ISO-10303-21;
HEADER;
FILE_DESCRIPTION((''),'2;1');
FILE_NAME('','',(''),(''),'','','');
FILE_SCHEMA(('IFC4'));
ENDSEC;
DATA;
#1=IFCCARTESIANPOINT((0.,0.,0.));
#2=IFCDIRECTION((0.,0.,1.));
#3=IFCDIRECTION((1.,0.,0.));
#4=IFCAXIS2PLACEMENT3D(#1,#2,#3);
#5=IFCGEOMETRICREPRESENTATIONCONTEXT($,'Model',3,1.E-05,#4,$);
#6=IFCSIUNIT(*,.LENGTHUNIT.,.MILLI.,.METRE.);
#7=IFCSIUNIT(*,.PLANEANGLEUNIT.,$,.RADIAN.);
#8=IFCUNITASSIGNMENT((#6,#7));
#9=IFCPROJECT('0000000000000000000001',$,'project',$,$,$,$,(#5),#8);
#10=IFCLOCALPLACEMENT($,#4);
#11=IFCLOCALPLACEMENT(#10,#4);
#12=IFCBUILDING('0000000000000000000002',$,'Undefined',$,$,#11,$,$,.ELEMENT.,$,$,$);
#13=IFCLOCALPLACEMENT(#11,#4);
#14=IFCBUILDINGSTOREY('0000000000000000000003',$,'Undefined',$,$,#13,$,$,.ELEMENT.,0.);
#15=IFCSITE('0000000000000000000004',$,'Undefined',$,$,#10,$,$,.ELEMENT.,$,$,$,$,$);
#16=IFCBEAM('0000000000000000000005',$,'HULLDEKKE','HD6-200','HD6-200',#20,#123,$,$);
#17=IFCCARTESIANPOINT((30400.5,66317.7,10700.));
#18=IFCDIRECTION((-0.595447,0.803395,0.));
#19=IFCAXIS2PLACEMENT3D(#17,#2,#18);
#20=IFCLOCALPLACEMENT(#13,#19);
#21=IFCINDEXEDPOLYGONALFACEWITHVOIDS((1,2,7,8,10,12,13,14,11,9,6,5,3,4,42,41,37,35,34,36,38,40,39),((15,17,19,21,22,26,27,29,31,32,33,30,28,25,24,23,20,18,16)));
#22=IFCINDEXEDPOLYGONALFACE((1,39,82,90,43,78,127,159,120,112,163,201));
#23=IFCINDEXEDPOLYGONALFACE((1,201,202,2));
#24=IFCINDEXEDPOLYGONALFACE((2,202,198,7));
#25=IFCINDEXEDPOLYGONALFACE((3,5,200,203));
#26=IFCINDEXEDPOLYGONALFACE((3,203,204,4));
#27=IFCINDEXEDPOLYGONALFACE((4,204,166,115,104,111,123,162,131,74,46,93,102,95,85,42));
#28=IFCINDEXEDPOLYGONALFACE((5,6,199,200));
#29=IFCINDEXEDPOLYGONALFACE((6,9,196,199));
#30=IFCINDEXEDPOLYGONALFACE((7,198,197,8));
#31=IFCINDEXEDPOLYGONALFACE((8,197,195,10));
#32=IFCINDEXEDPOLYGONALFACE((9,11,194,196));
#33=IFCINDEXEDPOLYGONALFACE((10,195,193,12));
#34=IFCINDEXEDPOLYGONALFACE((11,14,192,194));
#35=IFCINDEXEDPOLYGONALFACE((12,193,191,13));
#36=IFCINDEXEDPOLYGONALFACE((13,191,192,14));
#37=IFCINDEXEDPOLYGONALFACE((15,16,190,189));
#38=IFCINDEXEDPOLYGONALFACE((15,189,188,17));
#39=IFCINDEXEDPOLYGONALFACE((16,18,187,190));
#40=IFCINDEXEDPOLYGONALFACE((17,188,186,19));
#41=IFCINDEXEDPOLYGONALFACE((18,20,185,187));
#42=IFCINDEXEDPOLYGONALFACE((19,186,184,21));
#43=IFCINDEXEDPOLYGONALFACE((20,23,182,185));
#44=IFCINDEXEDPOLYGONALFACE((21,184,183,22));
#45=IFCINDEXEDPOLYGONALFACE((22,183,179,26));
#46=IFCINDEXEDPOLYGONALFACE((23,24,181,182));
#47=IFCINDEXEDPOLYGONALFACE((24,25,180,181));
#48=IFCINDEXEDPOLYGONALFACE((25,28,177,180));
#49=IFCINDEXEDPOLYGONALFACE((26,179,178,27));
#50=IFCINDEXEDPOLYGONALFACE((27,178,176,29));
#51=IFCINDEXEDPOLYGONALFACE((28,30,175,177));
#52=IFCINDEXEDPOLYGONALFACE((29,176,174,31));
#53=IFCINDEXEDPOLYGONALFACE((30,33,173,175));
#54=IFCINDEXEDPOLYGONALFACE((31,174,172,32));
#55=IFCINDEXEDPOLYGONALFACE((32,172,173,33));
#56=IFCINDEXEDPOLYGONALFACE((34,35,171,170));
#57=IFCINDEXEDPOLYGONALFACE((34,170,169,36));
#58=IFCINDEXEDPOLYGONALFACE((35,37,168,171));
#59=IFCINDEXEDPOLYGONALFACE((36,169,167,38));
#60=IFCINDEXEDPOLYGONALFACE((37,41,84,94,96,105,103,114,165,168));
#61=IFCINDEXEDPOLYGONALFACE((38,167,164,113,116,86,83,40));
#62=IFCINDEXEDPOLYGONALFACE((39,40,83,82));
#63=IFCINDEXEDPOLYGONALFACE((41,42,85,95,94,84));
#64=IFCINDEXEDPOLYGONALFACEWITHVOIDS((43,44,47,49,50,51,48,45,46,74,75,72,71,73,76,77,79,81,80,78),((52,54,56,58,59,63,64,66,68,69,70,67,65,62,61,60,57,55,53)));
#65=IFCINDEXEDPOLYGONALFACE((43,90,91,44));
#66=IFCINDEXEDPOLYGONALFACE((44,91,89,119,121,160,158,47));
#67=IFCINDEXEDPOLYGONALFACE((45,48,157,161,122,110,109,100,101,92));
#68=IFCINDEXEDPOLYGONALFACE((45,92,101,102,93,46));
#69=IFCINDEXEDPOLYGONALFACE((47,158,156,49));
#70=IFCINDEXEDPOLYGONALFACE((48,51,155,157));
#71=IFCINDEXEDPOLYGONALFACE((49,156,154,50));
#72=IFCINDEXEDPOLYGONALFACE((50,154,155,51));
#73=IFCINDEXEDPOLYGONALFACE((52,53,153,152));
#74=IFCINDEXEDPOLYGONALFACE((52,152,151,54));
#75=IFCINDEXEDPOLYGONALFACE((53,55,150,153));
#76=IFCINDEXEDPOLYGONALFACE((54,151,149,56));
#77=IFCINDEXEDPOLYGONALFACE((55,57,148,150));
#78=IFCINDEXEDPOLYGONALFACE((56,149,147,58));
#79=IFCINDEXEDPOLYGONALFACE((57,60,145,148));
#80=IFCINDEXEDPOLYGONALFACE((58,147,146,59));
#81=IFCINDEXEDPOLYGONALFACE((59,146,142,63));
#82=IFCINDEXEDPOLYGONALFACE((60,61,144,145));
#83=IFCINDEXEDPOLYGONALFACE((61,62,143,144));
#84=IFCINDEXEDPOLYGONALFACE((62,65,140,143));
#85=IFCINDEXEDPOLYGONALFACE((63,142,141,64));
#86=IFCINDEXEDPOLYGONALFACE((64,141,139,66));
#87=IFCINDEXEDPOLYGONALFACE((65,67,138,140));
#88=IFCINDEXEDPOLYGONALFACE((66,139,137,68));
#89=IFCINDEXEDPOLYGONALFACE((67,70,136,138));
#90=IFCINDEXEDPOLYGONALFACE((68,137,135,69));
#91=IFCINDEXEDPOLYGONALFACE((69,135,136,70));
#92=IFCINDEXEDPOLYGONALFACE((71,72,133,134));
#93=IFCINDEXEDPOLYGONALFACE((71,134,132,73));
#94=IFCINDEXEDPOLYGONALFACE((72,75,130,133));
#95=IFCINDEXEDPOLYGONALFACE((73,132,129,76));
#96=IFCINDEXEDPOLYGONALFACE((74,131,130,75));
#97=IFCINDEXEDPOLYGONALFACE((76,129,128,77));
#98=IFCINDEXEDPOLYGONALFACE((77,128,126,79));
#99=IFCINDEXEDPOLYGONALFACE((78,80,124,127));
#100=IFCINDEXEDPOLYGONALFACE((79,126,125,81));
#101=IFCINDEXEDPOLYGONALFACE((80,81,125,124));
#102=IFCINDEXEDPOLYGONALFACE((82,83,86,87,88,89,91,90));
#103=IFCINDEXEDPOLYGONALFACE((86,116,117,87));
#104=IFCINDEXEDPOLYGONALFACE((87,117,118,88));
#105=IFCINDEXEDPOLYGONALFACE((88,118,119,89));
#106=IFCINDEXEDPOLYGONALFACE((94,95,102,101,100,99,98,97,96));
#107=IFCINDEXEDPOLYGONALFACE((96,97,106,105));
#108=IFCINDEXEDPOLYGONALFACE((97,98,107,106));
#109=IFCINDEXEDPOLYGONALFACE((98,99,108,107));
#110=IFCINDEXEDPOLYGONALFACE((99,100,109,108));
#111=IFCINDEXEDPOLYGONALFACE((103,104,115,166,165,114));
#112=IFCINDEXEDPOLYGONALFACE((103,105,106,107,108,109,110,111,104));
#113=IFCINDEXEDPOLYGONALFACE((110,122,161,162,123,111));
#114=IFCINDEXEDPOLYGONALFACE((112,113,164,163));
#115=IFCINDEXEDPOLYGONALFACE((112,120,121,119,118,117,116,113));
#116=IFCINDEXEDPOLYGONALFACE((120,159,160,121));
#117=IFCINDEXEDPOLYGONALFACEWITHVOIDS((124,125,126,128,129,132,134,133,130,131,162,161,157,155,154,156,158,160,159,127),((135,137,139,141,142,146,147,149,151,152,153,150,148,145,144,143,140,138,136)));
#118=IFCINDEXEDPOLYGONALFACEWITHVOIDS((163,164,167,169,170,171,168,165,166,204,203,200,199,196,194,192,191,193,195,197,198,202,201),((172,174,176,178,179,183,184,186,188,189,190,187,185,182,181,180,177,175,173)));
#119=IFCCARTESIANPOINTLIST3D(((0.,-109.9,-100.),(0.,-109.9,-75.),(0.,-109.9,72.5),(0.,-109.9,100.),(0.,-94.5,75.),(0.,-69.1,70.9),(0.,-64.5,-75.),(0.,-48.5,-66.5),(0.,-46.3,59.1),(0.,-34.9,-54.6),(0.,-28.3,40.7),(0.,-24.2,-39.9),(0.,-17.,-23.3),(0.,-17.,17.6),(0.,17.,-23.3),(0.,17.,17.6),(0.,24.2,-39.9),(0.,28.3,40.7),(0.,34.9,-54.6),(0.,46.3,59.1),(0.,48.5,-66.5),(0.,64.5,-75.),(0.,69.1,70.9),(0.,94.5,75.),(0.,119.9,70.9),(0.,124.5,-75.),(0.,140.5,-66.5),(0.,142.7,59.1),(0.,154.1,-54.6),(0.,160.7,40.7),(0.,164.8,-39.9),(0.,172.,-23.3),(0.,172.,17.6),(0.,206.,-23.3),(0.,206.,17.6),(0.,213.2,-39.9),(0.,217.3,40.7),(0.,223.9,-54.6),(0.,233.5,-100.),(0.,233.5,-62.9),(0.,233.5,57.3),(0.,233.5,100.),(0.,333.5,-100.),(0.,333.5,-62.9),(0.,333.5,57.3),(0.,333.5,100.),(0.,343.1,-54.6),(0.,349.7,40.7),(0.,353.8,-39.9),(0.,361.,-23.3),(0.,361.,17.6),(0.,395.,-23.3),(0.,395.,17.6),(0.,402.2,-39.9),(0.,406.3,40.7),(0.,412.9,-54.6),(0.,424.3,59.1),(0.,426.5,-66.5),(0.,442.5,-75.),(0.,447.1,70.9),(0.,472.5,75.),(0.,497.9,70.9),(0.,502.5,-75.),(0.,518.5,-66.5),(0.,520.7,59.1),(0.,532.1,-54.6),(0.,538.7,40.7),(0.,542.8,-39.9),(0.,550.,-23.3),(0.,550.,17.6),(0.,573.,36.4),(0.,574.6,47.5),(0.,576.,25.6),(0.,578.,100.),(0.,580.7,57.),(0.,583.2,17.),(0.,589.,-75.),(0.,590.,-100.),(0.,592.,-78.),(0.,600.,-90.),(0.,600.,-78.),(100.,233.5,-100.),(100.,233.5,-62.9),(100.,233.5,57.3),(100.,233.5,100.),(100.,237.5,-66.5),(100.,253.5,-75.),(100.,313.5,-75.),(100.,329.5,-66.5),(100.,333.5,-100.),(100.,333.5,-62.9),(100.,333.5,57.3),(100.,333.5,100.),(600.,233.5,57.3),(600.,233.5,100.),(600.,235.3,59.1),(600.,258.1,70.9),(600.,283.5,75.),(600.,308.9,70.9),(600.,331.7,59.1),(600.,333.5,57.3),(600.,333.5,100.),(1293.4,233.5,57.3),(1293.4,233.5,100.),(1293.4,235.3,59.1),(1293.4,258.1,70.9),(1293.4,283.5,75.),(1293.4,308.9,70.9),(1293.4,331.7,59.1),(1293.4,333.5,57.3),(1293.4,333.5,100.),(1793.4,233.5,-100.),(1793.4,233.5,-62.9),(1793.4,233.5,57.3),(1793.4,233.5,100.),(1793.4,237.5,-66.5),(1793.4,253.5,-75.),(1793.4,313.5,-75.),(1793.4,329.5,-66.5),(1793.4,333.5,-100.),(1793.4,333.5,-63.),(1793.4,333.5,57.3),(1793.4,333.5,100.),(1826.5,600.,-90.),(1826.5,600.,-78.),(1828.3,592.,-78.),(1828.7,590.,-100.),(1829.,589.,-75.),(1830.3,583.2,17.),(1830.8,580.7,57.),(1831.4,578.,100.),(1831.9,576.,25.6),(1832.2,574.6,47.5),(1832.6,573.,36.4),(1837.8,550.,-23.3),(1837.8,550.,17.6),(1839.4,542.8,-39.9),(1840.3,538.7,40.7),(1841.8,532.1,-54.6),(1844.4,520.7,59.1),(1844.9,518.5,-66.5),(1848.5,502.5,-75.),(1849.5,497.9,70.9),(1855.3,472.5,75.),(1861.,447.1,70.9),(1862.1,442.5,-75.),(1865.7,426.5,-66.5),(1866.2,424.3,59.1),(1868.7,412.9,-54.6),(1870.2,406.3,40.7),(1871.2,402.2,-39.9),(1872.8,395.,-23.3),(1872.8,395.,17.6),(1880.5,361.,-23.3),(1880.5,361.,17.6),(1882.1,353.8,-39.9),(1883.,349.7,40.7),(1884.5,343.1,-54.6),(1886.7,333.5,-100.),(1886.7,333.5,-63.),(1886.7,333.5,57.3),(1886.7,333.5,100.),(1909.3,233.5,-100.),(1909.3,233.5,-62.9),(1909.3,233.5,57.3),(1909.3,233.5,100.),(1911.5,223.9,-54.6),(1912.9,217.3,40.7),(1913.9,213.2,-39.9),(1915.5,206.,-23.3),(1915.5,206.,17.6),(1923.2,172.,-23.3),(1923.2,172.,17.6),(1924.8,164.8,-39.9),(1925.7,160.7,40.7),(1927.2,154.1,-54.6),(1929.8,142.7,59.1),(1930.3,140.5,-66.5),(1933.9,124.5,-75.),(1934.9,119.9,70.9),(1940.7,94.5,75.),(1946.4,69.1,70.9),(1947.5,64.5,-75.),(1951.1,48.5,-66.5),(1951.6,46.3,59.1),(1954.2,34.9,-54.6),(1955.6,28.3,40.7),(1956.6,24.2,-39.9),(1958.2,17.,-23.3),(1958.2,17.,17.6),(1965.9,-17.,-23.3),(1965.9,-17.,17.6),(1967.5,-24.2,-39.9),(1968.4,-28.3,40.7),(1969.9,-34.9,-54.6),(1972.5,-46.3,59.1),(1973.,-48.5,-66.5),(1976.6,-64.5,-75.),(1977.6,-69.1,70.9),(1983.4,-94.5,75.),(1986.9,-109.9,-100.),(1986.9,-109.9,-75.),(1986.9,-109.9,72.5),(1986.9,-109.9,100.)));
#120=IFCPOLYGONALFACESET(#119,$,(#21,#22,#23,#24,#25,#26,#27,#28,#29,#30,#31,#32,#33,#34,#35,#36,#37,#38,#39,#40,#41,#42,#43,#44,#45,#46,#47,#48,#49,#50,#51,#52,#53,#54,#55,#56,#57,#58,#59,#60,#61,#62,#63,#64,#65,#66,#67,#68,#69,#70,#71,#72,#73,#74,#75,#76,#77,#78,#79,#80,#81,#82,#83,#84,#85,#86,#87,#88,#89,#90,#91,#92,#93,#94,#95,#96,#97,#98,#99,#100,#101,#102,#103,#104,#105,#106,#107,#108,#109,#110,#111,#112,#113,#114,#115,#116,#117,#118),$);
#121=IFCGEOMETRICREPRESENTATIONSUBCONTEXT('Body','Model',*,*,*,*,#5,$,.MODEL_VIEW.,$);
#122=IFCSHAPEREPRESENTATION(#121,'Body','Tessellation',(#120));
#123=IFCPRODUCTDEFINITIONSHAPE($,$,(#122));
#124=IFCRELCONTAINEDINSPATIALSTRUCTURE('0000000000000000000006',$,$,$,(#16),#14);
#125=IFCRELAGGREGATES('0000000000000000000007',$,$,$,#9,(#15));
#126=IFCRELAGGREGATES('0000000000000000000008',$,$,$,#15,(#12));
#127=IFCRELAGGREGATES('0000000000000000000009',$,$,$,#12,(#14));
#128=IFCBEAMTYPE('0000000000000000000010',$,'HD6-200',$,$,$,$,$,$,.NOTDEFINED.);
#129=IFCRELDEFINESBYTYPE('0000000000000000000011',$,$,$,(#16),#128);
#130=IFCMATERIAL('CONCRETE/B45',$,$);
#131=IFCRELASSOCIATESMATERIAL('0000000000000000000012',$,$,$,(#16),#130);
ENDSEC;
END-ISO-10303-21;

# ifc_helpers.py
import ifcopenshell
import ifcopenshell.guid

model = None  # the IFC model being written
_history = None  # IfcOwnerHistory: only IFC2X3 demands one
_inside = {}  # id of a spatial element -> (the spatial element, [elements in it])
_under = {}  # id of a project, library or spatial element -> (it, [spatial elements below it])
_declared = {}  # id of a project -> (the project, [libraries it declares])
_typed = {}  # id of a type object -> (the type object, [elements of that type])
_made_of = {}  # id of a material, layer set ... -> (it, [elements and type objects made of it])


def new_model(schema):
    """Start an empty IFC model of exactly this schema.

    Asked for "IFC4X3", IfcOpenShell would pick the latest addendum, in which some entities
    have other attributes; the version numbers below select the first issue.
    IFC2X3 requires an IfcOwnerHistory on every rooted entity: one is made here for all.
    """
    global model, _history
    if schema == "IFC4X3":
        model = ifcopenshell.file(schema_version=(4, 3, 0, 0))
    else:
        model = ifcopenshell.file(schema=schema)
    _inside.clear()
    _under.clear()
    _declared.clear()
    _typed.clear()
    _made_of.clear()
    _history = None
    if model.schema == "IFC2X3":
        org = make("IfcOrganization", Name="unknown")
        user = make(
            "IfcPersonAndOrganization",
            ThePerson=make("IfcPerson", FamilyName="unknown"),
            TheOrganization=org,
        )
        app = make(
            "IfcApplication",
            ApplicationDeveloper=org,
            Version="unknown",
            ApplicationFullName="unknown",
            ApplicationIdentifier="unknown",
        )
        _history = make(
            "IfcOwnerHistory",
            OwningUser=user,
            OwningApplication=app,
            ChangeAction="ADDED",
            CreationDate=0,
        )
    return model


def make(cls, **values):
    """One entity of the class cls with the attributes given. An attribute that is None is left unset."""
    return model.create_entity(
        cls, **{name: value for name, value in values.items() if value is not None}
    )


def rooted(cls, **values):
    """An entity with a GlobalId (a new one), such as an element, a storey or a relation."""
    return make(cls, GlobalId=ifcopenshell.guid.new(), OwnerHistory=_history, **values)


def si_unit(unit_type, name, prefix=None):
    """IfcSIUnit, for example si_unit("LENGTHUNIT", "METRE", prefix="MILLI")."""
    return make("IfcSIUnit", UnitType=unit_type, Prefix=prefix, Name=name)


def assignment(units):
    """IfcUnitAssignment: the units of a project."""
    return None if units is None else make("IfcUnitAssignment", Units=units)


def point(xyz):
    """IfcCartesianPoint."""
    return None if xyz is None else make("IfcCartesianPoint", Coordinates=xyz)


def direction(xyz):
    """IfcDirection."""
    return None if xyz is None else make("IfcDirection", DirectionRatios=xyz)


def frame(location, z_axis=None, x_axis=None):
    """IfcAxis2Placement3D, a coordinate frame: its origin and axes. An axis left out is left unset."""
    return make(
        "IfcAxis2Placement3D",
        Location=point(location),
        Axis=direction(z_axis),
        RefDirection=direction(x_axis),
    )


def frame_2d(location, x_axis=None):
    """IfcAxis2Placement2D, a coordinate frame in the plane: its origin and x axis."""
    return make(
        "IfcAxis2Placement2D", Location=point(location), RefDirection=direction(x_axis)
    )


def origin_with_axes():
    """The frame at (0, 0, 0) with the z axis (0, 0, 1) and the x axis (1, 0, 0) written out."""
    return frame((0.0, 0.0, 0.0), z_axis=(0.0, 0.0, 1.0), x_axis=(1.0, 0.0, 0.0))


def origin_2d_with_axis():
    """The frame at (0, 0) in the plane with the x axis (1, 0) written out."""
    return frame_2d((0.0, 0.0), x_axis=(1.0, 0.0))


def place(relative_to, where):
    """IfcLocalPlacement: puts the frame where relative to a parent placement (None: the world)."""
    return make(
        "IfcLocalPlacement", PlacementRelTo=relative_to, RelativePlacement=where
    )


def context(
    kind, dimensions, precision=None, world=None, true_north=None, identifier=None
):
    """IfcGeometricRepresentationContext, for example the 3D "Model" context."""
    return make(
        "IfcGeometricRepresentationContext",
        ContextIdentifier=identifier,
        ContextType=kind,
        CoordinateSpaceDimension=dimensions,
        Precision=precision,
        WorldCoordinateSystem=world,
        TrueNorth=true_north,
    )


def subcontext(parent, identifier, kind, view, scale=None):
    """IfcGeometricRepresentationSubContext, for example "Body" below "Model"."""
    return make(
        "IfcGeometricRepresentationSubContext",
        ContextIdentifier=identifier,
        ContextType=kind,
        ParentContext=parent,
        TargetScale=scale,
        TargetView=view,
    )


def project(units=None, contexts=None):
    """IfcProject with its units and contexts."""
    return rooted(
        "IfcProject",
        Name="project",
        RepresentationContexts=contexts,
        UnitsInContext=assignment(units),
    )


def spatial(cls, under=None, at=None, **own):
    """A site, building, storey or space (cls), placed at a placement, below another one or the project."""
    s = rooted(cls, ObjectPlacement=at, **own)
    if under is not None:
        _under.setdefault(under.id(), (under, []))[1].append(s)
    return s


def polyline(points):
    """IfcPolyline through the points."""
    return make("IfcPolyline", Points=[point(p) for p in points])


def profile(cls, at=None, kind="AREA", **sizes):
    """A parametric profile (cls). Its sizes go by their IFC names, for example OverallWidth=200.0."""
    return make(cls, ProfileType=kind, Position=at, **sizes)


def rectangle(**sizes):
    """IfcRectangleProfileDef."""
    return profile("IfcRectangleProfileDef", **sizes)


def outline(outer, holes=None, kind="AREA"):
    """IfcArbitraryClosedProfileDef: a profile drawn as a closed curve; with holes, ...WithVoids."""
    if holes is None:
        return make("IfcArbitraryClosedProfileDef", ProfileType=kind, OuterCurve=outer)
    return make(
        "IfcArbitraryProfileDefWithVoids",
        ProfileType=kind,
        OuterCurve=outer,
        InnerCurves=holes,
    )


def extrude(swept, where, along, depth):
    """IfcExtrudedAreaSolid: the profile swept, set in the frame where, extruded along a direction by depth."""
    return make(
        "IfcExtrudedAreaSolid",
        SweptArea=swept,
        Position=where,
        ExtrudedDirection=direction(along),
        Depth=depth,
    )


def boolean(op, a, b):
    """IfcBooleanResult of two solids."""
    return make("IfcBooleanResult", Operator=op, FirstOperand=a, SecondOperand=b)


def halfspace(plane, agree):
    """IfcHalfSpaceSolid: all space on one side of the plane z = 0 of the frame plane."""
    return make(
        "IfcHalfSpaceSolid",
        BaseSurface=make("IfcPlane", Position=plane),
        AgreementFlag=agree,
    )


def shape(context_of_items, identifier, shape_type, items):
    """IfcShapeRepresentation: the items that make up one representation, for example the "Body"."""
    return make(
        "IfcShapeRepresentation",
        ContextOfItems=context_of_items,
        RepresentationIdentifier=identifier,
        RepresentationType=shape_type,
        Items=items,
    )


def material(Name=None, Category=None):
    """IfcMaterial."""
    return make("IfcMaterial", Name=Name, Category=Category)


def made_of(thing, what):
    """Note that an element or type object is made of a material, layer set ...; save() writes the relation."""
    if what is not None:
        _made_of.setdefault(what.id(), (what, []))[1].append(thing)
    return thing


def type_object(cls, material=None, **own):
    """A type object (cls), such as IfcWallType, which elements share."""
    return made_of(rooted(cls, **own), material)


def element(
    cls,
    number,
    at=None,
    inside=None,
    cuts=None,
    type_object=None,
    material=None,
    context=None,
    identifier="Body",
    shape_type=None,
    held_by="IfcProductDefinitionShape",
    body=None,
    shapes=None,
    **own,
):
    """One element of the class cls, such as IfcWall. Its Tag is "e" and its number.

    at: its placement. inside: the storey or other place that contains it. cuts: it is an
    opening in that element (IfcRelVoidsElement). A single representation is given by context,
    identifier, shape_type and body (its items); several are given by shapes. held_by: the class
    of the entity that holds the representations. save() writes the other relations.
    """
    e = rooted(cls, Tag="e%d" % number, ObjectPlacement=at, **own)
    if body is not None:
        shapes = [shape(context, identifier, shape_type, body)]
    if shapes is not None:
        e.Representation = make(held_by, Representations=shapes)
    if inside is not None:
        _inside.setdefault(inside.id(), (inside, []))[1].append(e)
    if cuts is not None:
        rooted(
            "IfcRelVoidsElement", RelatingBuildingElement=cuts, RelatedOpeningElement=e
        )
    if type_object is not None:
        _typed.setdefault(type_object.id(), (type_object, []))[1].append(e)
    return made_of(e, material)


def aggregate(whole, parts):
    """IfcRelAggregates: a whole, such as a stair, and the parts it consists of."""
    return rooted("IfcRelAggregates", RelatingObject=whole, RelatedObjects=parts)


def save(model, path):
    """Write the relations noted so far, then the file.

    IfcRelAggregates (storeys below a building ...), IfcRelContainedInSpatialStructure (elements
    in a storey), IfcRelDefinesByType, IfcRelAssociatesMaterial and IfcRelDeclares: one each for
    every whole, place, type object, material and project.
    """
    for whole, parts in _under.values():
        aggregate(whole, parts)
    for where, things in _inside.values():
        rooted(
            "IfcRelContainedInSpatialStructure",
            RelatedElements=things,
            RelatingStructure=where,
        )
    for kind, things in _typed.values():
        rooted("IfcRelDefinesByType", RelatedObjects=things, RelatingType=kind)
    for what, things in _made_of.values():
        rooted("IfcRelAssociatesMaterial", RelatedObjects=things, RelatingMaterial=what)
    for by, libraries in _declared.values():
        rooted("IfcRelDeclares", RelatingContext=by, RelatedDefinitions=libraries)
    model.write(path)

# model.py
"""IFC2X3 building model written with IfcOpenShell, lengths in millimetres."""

from ifc_helpers import new_model, si_unit, frame, origin_with_axes, origin_2d_with_axis, place, context, subcontext, project, spatial, polyline, rectangle, outline, extrude, boolean, halfspace, material, type_object, element, save


model = new_model("IFC2X3")

# Units and contexts
model_context = context("Model", 3, precision=1e-05, world=origin_with_axes())
body_context = subcontext(model_context, "Body", "Model", "MODEL_VIEW")
ifc_project = project(units=[si_unit("LENGTHUNIT", "METRE", prefix="MILLI"), si_unit("PLANEANGLEUNIT", "RADIAN")], contexts=[model_context])

# Site, building, storey
site_placement = place(None, origin_with_axes())
site = spatial("IfcSite", under=ifc_project, at=site_placement, Name="Undefined", CompositionType="ELEMENT")
building_placement = place(site_placement, origin_with_axes())
building = spatial("IfcBuilding", under=site, at=building_placement, Name="Undefined", CompositionType="ELEMENT")
storey_placement = place(building_placement, origin_with_axes())
storey = spatial("IfcBuildingStorey", under=building, at=storey_placement, Name="Undefined", CompositionType="ELEMENT", Elevation=0.0)

# Beam
ifc_material_1 = material(Name="CONCRETE/B45")
beam_type_1 = type_object("IfcBeamType", Name="HD6-200", PredefinedType="NOTDEFINED")
beam_1_placement = place(storey_placement, frame((30400.5, 66317.7, 10700.0), z_axis=(0.0, 0.0, 1.0), x_axis=(-0.595447, 0.803395, 0.0)))
element("IfcBeam", 1, at=beam_1_placement, inside=storey, type_object=beam_type_1, material=ifc_material_1, Name="HULLDEKKE", Description="HD6-200", ObjectType="HD6-200", context=body_context, shape_type="CSG", body=[
    boolean("DIFFERENCE", boolean("DIFFERENCE", boolean("DIFFERENCE", boolean("DIFFERENCE", boolean("DIFFERENCE", boolean("DIFFERENCE", extrude(outline(polyline([(589.0, -75.0), (592.0, -78.0), (600.0, -78.0), (600.0, -90.0), (590.0, -100.0), (-590.0, -100.0), (-600.0, -90.0), (-600.0, -78.0), (-592.0, -78.0), (-589.0, -75.0), (-583.2, 17.0), (-576.0, 25.6), (-573.0, 36.4), (-574.6, 47.5), (-580.7, 57.0), (-578.0, 100.0), (578.0, 100.0), (580.7, 57.0), (574.6, 47.5), (573.0, 36.4), (576.0, 25.6), (583.2, 17.0), (589.0, -75.0)]), holes=[polyline([(542.8, -39.9), (550.0, -23.3), (550.0, 17.5), (538.7, 40.7), (520.7, 59.1), (497.9, 70.9), (472.5, 75.0), (447.1, 70.9), (424.3, 59.1), (406.3, 40.7), (395.0, 17.5), (395.0, -23.3), (402.2, -39.9), (412.9, -54.6), (426.5, -66.5), (442.5, -75.0), (502.5, -75.0), (518.5, -66.5), (532.1, -54.6), (542.8, -39.9)]), polyline([(353.8, -39.9), (361.0, -23.3), (361.0, 17.5), (349.7, 40.7), (331.7, 59.1), (308.9, 70.9), (283.5, 75.0), (258.1, 70.9), (235.3, 59.1), (217.3, 40.7), (206.0, 17.5), (206.0, -23.3), (213.2, -39.9), (223.9, -54.6), (237.5, -66.5), (253.5, -75.0), (313.5, -75.0), (329.5, -66.5), (343.1, -54.6), (353.8, -39.9)]), polyline([(164.8, -39.9), (172.0, -23.3), (172.0, 17.5), (160.7, 40.7), (142.7, 59.1), (119.9, 70.9), (94.5, 75.0), (69.1, 70.9), (46.3, 59.1), (28.3, 40.7), (17.0, 17.5), (17.0, -23.3), (24.2, -39.9), (34.9, -54.6), (48.5, -66.5), (64.5, -75.0), (124.5, -75.0), (140.5, -66.5), (154.1, -54.6), (164.8, -39.9)]), polyline([(-24.2, -39.9), (-17.0, -23.3), (-17.0, 17.5), (-28.3, 40.7), (-46.3, 59.1), (-69.1, 70.9), (-94.5, 75.0), (-119.9, 70.9), (-142.7, 59.1), (-160.7, 40.7), (-172.0, 17.5), (-172.0, -23.3), (-164.8, -39.9), (-154.1, -54.6), (-140.5, -66.5), (-124.5, -75.0), (-64.5, -75.0), (-48.5, -66.5), (-34.9, -54.6), (-24.2, -39.9)]), polyline([(-213.2, -39.9), (-206.0, -23.3), (-206.0, 17.5), (-217.3, 40.7), (-235.3, 59.1), (-258.1, 70.9), (-283.5, 75.0), (-308.9, 70.9), (-331.7, 59.1), (-349.7, 40.7), (-361.0, 17.5), (-361.0, -23.3), (-353.8, -39.9), (-343.1, -54.6), (-329.5, -66.5), (-313.5, -75.0), (-253.5, -75.0), (-237.5, -66.5), (-223.9, -54.6), (-213.2, -39.9)]), polyline([(-402.2, -39.9), (-395.0, -23.3), (-395.0, 17.5), (-406.3, 40.7), (-424.3, 59.1), (-447.1, 70.9), (-472.5, 75.0), (-497.9, 70.9), (-520.7, 59.1), (-538.7, 40.7), (-550.0, 17.5), (-550.0, -23.3), (-542.8, -39.9), (-532.1, -54.6), (-518.5, -66.5), (-502.5, -75.0), (-442.5, -75.0), (-426.5, -66.5), (-412.9, -54.6), (-402.2, -39.9)])]), frame((2173.4, 0.0, 0.0), z_axis=(-1.0, 0.0, 0.0), x_axis=(0.0, -1.0, 0.0)), (0.0, 0.0, 1.0), 2173.4), extrude(rectangle(XDim=100.0, YDim=215.0, at=origin_2d_with_axis()), frame((100.0, 283.5, 2.5), z_axis=(-1.0, 0.0, 0.0), x_axis=(0.0, 1.0, 0.0)), (0.0, 0.0, 1.0), 170.0)), extrude(rectangle(XDim=100.0, YDim=165.0, at=origin_2d_with_axis()), frame((600.0, 283.5, 22.5), z_axis=(-1.0, 0.0, 0.0), x_axis=(0.0, -1.0, 0.0)), (0.0, 0.0, 1.0), 670.0)), extrude(rectangle(XDim=100.0, YDim=215.0, at=origin_2d_with_axis()), frame((1793.4, 283.5, 2.5), z_axis=(1.0, 0.0, 0.0), x_axis=(0.0, -1.0, 0.0)), (0.0, 0.0, 1.0), 170.0)), extrude(rectangle(XDim=100.0, YDim=165.0, at=origin_2d_with_axis()), frame((1293.4, 283.5, 22.5), z_axis=(1.0, 0.0, 0.0), x_axis=(0.0, 1.0, 0.0)), (0.0, 0.0, 1.0), 670.0)), halfspace(frame((1826.5, 600.0, 100.0), z_axis=(0.975413, 0.220384, 0.0), x_axis=(0.0, 0.0, -1.0)), False)), halfspace(frame((0.0, -109.9, -100.0), z_axis=(0.0, -1.0, 0.0), x_axis=(0.0, 0.0, 1.0)), False)),
])

save(model, "model.ifc")
